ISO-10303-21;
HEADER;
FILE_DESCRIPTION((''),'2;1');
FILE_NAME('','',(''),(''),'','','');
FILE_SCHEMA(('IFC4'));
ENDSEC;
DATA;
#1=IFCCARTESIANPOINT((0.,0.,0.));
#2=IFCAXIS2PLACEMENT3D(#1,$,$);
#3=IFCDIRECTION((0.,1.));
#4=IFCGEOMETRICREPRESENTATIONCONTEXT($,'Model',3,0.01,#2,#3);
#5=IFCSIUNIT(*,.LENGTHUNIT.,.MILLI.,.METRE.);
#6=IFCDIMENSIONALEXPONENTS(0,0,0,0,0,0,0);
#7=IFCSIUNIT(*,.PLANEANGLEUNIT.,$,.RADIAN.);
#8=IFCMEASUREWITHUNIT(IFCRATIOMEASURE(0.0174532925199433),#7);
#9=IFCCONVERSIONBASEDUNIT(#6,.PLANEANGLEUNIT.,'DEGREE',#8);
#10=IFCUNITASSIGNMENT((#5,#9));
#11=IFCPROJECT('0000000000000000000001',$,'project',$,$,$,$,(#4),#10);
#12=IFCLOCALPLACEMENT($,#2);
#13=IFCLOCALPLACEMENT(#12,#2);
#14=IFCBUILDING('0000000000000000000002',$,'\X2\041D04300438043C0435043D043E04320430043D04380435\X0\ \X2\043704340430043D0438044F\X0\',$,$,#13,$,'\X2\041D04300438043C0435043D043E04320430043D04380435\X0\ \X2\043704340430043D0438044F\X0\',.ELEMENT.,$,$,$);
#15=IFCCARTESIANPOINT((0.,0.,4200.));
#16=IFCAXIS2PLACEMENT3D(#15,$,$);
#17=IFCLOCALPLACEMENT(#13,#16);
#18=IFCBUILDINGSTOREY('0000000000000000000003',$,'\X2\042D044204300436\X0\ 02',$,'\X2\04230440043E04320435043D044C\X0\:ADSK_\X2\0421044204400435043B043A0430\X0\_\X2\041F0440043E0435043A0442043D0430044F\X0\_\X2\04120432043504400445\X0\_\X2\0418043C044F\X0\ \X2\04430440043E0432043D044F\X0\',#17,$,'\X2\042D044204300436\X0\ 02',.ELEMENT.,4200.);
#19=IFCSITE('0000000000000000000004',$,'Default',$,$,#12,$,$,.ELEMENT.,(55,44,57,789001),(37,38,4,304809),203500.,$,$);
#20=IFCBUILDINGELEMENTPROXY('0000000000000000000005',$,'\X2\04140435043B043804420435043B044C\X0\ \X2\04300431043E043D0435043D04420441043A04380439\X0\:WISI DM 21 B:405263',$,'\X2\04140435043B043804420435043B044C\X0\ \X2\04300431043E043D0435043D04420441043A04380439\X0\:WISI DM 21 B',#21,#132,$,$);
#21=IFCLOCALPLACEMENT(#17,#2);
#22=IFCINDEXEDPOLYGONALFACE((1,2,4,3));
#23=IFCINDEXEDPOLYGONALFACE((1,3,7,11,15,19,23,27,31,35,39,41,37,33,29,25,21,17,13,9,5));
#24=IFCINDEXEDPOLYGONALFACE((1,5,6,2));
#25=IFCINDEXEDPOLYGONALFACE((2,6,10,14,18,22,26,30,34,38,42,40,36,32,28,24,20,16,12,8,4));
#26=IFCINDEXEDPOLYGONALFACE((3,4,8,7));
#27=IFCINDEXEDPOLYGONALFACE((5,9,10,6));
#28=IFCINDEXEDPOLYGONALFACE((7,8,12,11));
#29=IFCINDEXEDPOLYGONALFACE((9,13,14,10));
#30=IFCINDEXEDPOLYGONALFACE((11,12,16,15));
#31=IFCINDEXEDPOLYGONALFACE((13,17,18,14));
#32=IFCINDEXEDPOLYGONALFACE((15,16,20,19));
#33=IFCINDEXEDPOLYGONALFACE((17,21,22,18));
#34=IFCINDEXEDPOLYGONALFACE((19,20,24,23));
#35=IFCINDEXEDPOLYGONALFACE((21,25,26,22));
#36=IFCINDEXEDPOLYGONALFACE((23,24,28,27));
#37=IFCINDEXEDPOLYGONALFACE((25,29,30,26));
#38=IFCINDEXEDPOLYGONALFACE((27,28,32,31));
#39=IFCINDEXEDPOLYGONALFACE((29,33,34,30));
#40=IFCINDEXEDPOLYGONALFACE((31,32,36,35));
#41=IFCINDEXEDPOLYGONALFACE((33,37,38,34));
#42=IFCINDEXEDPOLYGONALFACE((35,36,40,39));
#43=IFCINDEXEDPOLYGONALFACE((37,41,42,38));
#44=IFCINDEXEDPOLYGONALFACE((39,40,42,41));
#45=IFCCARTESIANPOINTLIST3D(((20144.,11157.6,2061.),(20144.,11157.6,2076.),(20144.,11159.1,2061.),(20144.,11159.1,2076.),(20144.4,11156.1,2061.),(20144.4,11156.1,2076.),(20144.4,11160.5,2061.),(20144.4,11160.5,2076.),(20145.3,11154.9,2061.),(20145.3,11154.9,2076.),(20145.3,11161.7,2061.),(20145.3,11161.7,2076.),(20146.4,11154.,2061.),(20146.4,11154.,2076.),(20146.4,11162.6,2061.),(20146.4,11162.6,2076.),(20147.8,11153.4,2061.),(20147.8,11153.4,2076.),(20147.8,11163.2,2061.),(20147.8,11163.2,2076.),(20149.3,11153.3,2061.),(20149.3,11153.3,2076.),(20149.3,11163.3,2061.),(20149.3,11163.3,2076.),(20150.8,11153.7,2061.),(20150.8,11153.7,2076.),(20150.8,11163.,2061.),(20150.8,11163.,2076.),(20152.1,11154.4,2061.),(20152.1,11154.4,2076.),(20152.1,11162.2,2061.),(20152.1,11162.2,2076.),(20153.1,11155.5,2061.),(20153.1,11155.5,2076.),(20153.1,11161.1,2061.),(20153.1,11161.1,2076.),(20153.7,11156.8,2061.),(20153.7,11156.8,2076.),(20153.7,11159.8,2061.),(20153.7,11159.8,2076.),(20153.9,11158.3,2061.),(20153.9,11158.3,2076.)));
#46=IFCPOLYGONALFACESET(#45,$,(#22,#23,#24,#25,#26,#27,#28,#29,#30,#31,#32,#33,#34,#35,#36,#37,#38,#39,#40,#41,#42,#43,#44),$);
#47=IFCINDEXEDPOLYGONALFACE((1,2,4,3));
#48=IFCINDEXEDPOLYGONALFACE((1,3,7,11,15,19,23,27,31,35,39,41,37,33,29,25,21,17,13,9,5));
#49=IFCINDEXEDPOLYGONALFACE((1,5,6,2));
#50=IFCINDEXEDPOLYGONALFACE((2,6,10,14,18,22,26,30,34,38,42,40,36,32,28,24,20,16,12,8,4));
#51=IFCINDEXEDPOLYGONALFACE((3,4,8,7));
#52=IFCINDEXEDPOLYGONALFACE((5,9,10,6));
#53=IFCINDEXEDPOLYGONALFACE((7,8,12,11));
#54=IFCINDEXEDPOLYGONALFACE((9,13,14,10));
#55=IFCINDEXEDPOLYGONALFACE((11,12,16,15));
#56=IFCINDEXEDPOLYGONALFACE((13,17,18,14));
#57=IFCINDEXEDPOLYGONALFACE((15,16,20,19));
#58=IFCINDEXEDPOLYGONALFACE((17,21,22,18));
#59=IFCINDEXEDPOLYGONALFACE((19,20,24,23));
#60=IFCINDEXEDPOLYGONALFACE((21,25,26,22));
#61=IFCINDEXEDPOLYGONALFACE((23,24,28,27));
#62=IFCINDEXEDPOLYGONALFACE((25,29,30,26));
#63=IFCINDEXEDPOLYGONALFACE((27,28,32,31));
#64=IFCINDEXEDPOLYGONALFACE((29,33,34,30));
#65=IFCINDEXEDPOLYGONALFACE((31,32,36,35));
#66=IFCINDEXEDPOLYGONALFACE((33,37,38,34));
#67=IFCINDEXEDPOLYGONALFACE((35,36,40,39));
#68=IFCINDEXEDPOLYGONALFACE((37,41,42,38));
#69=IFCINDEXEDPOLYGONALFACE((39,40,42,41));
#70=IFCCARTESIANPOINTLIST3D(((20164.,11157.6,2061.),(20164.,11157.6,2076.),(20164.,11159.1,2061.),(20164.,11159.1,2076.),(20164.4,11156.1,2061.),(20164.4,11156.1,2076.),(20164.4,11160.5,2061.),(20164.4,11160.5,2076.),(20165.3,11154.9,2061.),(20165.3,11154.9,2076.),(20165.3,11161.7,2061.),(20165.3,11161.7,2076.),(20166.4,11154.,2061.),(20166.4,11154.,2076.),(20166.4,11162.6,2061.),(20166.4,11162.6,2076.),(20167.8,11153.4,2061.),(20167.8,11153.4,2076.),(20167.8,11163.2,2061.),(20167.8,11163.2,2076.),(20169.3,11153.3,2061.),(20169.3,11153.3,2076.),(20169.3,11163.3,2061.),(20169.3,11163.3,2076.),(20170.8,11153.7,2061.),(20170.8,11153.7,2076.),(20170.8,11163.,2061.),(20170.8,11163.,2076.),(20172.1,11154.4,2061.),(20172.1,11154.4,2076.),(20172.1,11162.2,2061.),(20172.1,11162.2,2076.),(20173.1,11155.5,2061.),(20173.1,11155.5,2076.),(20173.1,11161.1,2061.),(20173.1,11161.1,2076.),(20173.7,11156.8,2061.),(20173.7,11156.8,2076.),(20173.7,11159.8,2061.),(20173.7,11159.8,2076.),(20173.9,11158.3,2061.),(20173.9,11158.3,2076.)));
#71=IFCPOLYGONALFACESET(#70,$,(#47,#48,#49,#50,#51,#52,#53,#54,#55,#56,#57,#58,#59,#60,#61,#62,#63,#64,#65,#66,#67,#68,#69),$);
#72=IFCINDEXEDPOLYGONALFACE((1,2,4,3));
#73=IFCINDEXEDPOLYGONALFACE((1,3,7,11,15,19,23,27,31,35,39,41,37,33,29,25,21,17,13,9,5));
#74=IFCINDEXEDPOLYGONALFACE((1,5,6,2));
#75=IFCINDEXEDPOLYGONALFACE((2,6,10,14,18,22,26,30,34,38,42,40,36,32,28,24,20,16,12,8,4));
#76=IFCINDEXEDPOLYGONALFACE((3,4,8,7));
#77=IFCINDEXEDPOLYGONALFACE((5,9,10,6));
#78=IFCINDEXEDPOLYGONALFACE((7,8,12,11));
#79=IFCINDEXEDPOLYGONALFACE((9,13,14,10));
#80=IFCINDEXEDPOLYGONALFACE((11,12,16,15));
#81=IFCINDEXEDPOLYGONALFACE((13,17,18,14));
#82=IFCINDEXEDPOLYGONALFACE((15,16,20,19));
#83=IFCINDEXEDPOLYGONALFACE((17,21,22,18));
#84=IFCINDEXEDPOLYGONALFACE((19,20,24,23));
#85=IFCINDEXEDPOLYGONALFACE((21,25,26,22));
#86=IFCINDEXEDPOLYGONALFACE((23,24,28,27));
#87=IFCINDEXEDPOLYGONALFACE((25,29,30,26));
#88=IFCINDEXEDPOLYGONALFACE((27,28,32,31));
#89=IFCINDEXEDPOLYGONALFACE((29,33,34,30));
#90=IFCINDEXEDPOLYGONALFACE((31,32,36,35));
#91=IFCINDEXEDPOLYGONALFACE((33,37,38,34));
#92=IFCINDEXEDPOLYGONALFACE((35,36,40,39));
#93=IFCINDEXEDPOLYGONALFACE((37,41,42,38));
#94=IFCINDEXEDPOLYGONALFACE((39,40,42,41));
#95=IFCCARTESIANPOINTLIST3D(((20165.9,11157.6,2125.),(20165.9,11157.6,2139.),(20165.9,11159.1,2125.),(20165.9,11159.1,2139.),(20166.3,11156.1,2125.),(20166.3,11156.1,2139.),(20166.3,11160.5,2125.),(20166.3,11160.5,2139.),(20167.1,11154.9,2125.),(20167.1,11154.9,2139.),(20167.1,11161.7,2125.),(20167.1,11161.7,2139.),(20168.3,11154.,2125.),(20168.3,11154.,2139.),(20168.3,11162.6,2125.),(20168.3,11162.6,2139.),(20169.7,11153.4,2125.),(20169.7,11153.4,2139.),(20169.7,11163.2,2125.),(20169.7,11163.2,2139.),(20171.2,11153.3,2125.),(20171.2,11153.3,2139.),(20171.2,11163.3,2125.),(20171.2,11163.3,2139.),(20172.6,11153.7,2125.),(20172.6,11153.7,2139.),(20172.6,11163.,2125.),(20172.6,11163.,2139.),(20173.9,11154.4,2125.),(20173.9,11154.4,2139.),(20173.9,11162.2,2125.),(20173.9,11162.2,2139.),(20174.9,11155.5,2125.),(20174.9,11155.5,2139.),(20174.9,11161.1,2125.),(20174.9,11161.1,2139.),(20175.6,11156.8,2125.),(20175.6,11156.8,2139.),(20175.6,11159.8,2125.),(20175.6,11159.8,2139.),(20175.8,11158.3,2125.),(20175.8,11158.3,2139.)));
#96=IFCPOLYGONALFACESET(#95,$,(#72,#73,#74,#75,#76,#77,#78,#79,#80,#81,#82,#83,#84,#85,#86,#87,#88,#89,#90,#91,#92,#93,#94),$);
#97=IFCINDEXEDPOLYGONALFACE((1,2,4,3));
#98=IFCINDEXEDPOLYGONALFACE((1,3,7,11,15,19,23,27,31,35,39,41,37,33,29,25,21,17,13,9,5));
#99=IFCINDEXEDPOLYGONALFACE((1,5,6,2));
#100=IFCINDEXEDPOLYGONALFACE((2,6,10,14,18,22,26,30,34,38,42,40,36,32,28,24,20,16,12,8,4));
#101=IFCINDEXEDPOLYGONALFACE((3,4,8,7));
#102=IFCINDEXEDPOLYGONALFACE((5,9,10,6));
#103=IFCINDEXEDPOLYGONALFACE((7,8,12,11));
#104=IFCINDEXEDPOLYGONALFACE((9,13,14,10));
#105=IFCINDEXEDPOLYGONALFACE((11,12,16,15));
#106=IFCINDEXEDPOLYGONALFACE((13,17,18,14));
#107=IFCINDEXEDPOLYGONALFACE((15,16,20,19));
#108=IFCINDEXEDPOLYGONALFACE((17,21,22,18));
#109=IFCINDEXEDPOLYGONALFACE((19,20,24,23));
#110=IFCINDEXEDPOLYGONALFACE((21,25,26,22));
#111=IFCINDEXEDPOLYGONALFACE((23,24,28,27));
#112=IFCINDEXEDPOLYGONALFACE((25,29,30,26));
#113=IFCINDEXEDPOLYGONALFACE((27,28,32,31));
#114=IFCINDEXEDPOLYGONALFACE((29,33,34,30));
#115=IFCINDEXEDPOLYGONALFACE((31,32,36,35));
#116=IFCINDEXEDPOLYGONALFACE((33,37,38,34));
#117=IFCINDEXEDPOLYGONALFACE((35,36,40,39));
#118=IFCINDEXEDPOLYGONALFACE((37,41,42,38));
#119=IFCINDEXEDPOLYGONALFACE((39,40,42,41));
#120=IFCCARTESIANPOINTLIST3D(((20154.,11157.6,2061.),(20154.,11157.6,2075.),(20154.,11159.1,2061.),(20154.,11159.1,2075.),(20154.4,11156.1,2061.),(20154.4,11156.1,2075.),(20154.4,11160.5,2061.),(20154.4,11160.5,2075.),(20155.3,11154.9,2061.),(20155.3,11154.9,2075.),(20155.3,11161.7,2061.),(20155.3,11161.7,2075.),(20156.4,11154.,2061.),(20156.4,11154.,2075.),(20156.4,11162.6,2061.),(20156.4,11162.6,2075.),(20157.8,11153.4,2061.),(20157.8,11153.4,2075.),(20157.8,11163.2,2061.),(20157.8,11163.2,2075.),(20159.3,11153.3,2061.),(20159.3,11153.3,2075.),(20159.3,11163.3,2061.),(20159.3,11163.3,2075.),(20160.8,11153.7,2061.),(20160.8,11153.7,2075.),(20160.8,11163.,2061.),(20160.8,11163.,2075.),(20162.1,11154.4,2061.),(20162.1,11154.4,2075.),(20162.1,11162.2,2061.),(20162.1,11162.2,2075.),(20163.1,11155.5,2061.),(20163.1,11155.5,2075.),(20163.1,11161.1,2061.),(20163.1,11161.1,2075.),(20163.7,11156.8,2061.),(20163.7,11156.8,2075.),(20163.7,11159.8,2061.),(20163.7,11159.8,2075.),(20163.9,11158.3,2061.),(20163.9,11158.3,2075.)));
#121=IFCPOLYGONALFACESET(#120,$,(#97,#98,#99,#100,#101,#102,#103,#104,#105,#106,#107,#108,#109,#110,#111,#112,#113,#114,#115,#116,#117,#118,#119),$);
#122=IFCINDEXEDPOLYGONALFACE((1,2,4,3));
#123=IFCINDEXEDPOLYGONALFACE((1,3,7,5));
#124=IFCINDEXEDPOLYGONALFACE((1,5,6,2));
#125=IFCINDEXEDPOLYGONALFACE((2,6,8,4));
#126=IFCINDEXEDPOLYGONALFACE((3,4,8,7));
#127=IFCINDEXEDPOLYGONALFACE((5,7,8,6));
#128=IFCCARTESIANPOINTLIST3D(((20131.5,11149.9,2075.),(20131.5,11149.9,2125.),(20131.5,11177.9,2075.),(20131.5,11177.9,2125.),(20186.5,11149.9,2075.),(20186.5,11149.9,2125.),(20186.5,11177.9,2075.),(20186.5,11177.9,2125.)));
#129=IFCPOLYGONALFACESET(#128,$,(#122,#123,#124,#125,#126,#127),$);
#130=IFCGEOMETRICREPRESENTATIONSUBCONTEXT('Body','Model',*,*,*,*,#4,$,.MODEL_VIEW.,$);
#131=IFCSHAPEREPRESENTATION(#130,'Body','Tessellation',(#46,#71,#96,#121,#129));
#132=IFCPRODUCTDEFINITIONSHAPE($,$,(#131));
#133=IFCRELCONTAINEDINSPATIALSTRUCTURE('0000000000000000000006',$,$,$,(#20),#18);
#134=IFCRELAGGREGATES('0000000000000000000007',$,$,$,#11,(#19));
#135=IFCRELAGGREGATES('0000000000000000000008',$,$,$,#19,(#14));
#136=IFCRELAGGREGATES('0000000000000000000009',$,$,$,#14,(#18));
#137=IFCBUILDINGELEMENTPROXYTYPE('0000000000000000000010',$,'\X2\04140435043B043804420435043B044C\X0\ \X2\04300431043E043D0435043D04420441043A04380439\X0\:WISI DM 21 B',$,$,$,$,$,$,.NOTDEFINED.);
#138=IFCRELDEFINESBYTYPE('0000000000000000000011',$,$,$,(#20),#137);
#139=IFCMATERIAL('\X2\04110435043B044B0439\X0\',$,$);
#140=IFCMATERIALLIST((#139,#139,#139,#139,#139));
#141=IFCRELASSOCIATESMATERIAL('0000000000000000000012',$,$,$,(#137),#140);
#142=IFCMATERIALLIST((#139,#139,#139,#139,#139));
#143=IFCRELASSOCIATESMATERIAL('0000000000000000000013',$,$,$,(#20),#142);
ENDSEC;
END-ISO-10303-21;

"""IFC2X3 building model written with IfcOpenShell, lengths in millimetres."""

from ifc_helpers import new_model, entity, si_unit, converted_unit, direction, frame, frame_2d, origin, place, context, subcontext, project, spatial, rectangle, circle, extrude, source, transform, mapped, material, material_list, type_object, type_shapes, element, save


model = new_model("IFC2X3")

# Units and contexts
model_context = context("Model", 3, precision=0.01, world=origin(), true_north=direction((0.0, 1.0)))
body_context = subcontext(model_context, "Body", "Model", "MODEL_VIEW")
ifc_project = project(units=[si_unit("LENGTHUNIT", "METRE", prefix="MILLI"), converted_unit("PLANEANGLEUNIT", "DEGREE", entity("IfcRatioMeasure", 0.0174532925199433), si_unit("PLANEANGLEUNIT", "RADIAN"), dimensions=[0, 0, 0, 0, 0, 0, 0])], contexts=[model_context])

# Site, building, storey
site_placement = place(None, frame((0.0, 0.0, 0.0)))
site = spatial("IfcSite", under=ifc_project, at=site_placement, Name="Default", CompositionType="ELEMENT", RefLatitude=(55, 44, 57, 789001), RefLongitude=(37, 38, 4, 304809), RefElevation=203500.0)
building_placement = place(site_placement, origin())
building = spatial("IfcBuilding", under=site, at=building_placement, Name="Наименование здания", LongName="Наименование здания", CompositionType="ELEMENT")
storey_placement = place(building_placement, frame((0.0, 0.0, 4200.0)))
storey = spatial("IfcBuildingStorey", under=building, at=storey_placement, Name="Этаж 02", ObjectType="Уровень:ADSK_Стрелка_Проектная_Вверх_Имя уровня", LongName="Этаж 02", CompositionType="ELEMENT", Elevation=4200.0)

# Building element proxy
ifc_material_1 = material(Name="Белый")
ifc_material_list_1 = material_list([ifc_material_1, ifc_material_1, ifc_material_1, ifc_material_1, ifc_material_1])
ifc_material_list_2 = material_list([ifc_material_1, ifc_material_1, ifc_material_1, ifc_material_1, ifc_material_1])
building_element_proxy_type_1 = type_object("IfcBuildingElementProxyType", Name="Делитель абонентский:WISI DM 21 B", PredefinedType="NOTDEFINED", material=ifc_material_list_2)
shared_shape_1 = source(origin(), body_context, "Body", "SweptSolid", [
    extrude(circle(Radius=5.0, at=frame_2d((0.0, 0.0), x_axis=(1.0, 0.0))), frame((10.0, -39.0, 8.4), z_axis=(0.0, 1.0, 0.0), x_axis=(-1.0, 0.0, 0.0)), (0.0, 0.0, 1.0), 15.0),
    extrude(circle(Radius=5.0, at=frame_2d((0.0, 0.0), x_axis=(1.0, 0.0))), frame((-10.0, -39.0, 8.4), z_axis=(0.0, 1.0, 0.0), x_axis=(-1.0, 0.0, 0.0)), (0.0, 0.0, 1.0), 15.0),
    extrude(circle(Radius=5.0, at=frame_2d((0.0, 0.0), x_axis=(1.0, 0.0))), frame((-11.8, 25.0, 8.4), z_axis=(0.0, 1.0, 0.0), x_axis=(-1.0, 0.0, 0.0)), (0.0, 0.0, 1.0), 14.0),
    extrude(circle(Radius=5.0, at=frame_2d((0.0, 0.0), x_axis=(1.0, 0.0))), frame((0.0, -39.0, 8.4), z_axis=(0.0, 1.0, 0.0), x_axis=(-1.0, 0.0, 0.0)), (0.0, 0.0, 1.0), 14.0),
    extrude(rectangle(XDim=55.0, YDim=50.0, at=frame_2d((0.0, 0.0), x_axis=(1.0, 0.0))), frame((0.0, 0.0, 0.0), z_axis=(0.0, 0.0, 1.0), x_axis=(-1.0, 0.0, 0.0)), (0.0, 0.0, 1.0), 28.0),
])
type_shapes(building_element_proxy_type_1, [shared_shape_1])
proxy_1_placement = place(storey_placement, frame((20159.0, 11149.9, 2100.0), z_axis=(0.0, 1.0, 0.0), x_axis=(-1.0, 0.0, 0.0)))
element("IfcBuildingElementProxy", 1, at=proxy_1_placement, inside=storey, type_object=building_element_proxy_type_1, material=ifc_material_list_1, Name="Делитель абонентский:WISI DM 21 B:405263", ObjectType="Делитель абонентский:WISI DM 21 B", context=body_context, shape_type="MappedRepresentation", body=[
    mapped(shared_shape_1, transform((0.0, 0.0, 0.0), scale=1.0)),
])

save(model, "model.ifc")
